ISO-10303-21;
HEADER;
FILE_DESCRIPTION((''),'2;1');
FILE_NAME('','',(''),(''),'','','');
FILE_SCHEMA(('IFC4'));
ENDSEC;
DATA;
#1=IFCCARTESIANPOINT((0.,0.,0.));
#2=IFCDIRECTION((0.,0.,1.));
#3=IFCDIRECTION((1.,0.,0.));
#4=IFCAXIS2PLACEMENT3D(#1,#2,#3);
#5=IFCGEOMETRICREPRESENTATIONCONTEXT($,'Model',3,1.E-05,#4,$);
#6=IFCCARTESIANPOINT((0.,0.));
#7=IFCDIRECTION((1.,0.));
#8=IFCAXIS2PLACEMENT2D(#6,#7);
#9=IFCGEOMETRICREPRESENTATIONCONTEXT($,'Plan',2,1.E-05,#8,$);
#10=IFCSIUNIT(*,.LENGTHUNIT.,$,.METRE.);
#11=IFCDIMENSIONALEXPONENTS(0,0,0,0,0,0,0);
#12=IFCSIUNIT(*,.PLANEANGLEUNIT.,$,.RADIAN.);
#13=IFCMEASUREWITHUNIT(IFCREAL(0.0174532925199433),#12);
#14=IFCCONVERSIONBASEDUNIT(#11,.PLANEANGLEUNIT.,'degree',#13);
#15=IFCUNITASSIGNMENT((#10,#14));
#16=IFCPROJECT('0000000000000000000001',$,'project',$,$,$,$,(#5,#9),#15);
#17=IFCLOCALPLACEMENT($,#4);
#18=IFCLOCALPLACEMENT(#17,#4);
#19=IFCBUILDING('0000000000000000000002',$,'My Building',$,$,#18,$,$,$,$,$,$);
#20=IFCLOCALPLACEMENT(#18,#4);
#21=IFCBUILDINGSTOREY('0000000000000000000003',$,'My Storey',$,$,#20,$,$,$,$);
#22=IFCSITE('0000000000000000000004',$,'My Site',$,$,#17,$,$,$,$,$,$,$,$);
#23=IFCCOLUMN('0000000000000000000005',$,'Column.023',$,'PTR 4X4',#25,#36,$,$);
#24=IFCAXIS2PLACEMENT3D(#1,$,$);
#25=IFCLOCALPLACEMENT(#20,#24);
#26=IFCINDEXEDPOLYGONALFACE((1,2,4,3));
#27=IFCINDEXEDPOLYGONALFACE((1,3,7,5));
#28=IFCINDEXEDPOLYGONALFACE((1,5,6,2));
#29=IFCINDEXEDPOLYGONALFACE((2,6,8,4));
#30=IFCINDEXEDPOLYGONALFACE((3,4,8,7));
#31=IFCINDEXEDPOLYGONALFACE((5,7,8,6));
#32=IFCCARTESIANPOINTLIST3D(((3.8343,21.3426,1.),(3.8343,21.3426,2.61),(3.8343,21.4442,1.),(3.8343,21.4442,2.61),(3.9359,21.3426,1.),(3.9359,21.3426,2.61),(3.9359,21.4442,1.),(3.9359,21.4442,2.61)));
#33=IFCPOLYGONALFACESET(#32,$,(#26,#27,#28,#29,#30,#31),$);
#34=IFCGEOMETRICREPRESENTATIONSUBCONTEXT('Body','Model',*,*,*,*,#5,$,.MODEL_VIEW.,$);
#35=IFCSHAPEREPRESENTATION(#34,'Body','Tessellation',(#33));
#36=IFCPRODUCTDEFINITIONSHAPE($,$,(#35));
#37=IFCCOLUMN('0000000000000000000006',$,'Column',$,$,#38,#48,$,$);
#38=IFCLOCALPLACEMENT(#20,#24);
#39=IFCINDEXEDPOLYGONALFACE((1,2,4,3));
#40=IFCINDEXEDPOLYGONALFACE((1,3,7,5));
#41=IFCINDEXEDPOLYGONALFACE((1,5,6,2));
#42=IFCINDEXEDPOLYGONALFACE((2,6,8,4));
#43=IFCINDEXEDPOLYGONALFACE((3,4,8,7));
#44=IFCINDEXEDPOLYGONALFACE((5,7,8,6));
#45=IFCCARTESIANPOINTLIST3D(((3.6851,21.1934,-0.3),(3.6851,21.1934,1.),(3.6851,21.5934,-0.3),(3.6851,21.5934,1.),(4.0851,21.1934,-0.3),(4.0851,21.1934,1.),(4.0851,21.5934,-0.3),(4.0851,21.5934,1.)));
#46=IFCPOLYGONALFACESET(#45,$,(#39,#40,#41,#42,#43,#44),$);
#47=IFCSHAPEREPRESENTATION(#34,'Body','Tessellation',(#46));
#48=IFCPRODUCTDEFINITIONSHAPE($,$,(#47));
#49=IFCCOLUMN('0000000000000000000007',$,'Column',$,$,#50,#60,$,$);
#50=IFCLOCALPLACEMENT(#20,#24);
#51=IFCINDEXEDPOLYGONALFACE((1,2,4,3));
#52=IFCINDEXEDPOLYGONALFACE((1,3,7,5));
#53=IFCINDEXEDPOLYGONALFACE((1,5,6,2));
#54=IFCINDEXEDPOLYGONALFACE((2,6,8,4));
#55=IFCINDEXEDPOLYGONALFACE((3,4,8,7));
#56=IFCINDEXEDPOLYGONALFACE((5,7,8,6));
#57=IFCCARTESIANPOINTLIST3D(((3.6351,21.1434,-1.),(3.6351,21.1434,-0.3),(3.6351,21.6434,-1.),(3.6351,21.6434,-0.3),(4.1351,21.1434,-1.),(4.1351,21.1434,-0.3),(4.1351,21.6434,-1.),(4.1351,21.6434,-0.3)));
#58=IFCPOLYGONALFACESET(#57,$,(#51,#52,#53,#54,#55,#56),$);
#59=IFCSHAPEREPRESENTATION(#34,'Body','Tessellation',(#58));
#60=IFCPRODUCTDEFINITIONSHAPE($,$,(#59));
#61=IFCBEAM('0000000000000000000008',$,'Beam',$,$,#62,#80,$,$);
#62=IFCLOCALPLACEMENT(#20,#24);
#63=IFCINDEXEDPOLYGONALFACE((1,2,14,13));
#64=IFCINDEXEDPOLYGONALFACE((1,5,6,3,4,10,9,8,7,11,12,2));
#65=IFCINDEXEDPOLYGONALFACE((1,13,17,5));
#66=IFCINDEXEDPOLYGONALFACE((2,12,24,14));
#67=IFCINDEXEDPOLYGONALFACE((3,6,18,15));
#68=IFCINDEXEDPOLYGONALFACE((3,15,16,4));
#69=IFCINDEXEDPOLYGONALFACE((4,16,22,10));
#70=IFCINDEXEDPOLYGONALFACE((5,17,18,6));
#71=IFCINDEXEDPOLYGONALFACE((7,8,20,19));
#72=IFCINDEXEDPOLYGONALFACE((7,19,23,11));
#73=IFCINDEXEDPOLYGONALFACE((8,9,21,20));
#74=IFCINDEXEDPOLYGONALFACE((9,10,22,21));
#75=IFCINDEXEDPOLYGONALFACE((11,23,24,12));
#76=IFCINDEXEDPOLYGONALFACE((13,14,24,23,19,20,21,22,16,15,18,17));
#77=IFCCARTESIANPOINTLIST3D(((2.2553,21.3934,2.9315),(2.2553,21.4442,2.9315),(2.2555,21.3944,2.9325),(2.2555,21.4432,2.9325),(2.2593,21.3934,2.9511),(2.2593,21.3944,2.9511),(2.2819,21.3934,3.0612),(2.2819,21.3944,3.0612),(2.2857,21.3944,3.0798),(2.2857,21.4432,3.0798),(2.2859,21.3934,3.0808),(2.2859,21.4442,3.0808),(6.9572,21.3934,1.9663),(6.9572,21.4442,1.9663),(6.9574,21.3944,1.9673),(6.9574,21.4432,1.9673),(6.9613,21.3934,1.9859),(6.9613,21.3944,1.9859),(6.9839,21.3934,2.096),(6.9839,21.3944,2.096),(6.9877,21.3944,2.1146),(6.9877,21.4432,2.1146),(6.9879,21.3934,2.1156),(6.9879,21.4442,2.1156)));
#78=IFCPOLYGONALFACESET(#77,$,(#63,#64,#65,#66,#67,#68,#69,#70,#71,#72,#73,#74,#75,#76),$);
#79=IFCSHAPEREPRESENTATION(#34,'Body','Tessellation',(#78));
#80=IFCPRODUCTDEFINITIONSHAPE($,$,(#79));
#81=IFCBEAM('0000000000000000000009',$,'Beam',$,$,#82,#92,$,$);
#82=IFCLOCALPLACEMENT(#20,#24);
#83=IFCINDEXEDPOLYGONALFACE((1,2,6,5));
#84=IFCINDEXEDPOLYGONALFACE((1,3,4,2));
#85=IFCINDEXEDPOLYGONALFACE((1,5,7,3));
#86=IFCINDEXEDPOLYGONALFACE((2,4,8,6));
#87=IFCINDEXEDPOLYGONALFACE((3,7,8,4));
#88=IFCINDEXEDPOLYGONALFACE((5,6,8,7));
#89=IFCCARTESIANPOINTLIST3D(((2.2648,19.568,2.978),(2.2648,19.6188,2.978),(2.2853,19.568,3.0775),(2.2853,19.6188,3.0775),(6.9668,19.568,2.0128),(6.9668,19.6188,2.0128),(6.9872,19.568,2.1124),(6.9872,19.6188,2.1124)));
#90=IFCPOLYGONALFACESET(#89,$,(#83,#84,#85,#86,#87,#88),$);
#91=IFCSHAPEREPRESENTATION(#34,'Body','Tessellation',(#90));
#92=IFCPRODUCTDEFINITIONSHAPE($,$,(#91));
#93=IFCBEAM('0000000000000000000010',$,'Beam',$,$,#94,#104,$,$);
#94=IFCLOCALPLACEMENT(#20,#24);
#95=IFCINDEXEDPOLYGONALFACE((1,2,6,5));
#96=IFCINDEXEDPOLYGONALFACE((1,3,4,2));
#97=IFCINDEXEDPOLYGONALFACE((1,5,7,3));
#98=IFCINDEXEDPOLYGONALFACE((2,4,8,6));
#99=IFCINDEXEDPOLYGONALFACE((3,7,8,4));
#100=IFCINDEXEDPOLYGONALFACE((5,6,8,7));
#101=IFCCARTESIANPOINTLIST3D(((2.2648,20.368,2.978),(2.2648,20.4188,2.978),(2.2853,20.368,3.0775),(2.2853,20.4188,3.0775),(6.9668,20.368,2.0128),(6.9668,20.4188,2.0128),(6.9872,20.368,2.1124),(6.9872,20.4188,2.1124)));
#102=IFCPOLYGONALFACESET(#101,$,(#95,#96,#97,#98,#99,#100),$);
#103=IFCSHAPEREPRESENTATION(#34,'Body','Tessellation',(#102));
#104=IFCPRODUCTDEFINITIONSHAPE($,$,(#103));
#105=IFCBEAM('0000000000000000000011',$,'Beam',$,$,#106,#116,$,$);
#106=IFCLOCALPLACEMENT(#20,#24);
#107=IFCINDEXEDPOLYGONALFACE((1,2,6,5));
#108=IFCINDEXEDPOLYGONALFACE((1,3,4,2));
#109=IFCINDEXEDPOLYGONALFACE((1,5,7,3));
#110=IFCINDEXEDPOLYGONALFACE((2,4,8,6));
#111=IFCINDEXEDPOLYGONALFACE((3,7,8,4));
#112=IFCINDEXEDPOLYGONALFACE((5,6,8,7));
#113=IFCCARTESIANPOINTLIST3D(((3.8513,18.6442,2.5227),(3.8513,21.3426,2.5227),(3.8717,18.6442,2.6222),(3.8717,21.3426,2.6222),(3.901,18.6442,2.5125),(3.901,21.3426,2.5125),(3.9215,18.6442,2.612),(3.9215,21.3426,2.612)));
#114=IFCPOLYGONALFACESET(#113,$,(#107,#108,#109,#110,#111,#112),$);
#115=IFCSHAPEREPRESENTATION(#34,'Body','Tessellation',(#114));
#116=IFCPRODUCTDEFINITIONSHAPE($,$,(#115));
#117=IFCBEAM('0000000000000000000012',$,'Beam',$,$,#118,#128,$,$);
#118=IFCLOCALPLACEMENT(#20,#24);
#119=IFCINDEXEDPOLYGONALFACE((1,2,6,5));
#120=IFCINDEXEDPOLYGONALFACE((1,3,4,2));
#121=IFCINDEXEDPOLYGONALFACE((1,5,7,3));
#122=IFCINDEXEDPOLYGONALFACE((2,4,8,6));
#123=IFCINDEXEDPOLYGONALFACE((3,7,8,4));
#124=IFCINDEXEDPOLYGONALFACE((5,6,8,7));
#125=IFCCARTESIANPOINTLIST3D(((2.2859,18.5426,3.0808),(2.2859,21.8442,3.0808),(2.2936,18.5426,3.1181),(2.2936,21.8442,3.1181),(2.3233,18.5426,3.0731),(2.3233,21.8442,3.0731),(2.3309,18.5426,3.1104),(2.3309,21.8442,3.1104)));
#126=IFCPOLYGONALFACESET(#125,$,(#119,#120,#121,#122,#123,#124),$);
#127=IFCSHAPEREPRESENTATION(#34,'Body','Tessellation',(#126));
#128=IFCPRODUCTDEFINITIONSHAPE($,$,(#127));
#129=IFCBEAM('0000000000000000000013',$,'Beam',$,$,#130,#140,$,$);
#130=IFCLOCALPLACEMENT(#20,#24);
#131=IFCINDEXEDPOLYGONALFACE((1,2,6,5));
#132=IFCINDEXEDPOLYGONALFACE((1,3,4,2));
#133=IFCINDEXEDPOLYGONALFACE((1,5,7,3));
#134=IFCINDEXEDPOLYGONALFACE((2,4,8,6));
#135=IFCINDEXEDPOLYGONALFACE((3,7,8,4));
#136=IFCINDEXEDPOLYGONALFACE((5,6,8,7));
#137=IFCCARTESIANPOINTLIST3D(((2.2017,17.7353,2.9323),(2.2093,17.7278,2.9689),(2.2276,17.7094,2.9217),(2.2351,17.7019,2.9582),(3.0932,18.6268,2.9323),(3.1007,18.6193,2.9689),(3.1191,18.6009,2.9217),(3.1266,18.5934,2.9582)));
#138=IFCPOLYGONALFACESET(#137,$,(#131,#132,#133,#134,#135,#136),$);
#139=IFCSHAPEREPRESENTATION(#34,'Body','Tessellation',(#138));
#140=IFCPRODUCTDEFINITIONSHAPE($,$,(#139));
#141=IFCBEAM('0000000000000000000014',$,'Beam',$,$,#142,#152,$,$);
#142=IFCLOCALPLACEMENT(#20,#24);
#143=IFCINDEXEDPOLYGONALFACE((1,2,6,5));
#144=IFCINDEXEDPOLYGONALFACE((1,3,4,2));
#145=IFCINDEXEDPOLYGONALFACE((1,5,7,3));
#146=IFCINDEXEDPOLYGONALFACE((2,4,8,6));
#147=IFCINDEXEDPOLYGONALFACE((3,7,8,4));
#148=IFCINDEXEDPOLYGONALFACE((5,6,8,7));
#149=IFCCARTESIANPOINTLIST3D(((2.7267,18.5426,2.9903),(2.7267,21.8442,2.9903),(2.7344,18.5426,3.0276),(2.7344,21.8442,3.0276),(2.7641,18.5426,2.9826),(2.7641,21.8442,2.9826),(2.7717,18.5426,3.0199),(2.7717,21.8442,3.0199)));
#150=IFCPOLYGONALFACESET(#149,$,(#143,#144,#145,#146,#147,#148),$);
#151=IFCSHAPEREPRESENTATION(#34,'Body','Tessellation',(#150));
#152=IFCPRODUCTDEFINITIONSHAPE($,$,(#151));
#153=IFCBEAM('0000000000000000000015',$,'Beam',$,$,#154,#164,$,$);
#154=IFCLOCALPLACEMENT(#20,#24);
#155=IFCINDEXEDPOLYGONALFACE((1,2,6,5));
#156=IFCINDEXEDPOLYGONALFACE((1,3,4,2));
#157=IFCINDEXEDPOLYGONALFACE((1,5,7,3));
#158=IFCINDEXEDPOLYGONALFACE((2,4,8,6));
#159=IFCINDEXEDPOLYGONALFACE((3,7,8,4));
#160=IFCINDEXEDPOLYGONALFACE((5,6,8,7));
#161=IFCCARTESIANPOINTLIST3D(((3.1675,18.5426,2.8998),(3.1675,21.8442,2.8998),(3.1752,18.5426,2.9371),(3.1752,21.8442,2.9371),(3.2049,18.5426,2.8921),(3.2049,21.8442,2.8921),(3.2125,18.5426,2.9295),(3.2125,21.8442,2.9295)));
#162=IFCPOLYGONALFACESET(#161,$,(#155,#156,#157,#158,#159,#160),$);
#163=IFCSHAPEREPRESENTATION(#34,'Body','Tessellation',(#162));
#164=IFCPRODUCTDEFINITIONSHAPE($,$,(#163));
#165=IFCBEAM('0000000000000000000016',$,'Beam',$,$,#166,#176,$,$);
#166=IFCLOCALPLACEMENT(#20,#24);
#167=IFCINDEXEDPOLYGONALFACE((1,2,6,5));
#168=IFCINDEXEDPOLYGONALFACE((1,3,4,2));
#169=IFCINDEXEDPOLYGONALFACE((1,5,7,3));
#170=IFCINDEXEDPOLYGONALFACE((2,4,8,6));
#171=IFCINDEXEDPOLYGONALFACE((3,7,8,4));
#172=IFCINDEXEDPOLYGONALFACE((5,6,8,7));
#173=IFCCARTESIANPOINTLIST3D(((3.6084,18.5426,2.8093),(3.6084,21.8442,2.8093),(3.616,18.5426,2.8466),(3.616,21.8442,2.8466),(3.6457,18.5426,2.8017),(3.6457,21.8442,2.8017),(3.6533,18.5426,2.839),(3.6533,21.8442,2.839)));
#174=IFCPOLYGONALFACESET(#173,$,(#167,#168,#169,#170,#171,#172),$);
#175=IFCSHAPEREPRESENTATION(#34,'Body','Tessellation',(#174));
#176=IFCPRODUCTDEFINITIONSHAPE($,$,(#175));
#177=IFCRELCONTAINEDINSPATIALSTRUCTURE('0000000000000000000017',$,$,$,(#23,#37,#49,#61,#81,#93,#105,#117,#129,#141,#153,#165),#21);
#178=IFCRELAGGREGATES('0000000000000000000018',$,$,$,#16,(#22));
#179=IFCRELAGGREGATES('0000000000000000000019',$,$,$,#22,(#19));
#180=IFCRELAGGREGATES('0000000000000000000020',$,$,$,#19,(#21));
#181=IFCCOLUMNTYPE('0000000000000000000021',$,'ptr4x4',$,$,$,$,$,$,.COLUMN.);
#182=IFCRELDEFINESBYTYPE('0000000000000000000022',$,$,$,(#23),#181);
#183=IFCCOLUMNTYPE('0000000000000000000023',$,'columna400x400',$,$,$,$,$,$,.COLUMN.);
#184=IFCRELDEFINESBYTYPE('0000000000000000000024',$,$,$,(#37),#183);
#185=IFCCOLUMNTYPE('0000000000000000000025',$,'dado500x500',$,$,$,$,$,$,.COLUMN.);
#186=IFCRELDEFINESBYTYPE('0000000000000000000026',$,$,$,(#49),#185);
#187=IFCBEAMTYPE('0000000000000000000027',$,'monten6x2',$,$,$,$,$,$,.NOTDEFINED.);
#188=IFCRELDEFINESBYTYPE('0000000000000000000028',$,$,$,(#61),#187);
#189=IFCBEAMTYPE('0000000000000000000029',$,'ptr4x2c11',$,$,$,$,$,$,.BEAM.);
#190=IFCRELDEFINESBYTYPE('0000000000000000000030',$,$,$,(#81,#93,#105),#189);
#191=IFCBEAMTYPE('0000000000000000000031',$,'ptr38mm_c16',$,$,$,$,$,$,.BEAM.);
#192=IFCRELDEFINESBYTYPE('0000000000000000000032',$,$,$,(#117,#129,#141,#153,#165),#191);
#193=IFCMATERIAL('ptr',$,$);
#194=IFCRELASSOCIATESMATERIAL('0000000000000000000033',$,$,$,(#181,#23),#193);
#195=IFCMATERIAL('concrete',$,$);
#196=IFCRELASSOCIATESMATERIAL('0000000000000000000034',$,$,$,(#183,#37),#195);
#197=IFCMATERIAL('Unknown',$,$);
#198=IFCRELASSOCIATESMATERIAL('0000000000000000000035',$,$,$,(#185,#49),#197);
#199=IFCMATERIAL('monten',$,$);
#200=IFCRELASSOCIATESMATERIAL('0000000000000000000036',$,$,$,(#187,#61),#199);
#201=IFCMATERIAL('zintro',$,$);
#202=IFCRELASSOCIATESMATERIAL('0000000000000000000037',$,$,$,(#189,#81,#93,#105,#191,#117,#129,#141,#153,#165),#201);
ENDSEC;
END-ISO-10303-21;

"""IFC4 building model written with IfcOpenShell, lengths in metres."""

from ifc_helpers import new_model, entity, si_unit, converted_unit, frame, origin_with_axes, origin_2d_with_axis, place, context, subcontext, project, spatial, rectangle, c_section, extrude, material, material_profile, profile_set, profile_usage, type_object, element, save


model = new_model("IFC4")

# Units and contexts
model_context = context("Model", 3, precision=1e-05, world=origin_with_axes())
plan_context = context("Plan", 2, precision=1e-05, world=origin_2d_with_axis())
body_context = subcontext(model_context, "Body", "Model", "MODEL_VIEW")
ifc_project = project(units=[si_unit("LENGTHUNIT", "METRE"), converted_unit("PLANEANGLEUNIT", "degree", entity("IfcReal", 0.0174532925199433), si_unit("PLANEANGLEUNIT", "RADIAN"), dimensions=[0, 0, 0, 0, 0, 0, 0])], contexts=[model_context, plan_context])

# Site, building, storey
site_placement = place(None, origin_with_axes())
site = spatial("IfcSite", under=ifc_project, at=site_placement, Name="My Site")
building_placement = place(site_placement, origin_with_axes())
building = spatial("IfcBuilding", under=site, at=building_placement, Name="My Building")
storey_placement = place(building_placement, origin_with_axes())
storey = spatial("IfcBuildingStorey", under=building, at=storey_placement, Name="My Storey")

# Columns
ifc_material_1 = material(Name="ptr")
ifc_material_profile_1 = material_profile(ifc_material_1, rectangle(XDim=0.1016, YDim=0.1016))
ifc_profile_set_1 = profile_set([ifc_material_profile_1])
ifc_profile_usage_1 = profile_usage(ifc_profile_set_1, cardinal=5)
column_type_1 = type_object("IfcColumnType", Name="ptr4x4", PredefinedType="COLUMN", material=ifc_profile_set_1)
column_1_placement = place(storey_placement, frame((3.8851, 21.3934, 1.0), z_axis=(0.0, 0.0, 1.0), x_axis=(0.0, 1.0, 0.0)))
element("IfcColumn", 1, at=column_1_placement, inside=storey, type_object=column_type_1, material=ifc_profile_usage_1, Name="Column.023", ObjectType="PTR 4X4", context=body_context, shape_type="SweptSolid", body=[
    extrude(rectangle(XDim=0.1016, YDim=0.1016), origin_with_axes(), (0.0, 0.0, 1.0), 1.61),
])
ifc_material_2 = material(Name="concrete")
ifc_material_profile_2 = material_profile(ifc_material_2, rectangle(XDim=0.4, YDim=0.4))
ifc_profile_set_2 = profile_set([ifc_material_profile_2], Name="concrete")
ifc_profile_usage_2 = profile_usage(ifc_profile_set_2)
column_type_2 = type_object("IfcColumnType", Name="columna400x400", PredefinedType="COLUMN", material=ifc_profile_set_2)
column_2_placement = place(storey_placement, frame((3.8851, 21.3934, -0.3), z_axis=(0.0, 0.0, 1.0), x_axis=(1.0, 0.0, 0.0)))
element("IfcColumn", 2, at=column_2_placement, inside=storey, type_object=column_type_2, material=ifc_profile_usage_2, Name="Column", context=body_context, shape_type="SweptSolid", body=[
    extrude(rectangle(XDim=0.4, YDim=0.4), origin_with_axes(), (0.0, 0.0, 1.0), 1.3),
])
ifc_material_3 = material(Name="Unknown")
ifc_material_profile_3 = material_profile(ifc_material_3, rectangle(XDim=0.5, YDim=0.5))
ifc_profile_set_3 = profile_set([ifc_material_profile_3], Name="concrete")
ifc_profile_usage_3 = profile_usage(ifc_profile_set_3)
column_type_3 = type_object("IfcColumnType", Name="dado500x500", PredefinedType="COLUMN", material=ifc_profile_set_3)
column_3_placement = place(storey_placement, frame((3.8851, 21.3934, -1.0), z_axis=(0.0, 0.0, 1.0), x_axis=(1.0, 0.0, 0.0)))
element("IfcColumn", 3, at=column_3_placement, inside=storey, type_object=column_type_3, material=ifc_profile_usage_3, Name="Column", context=body_context, shape_type="SweptSolid", body=[
    extrude(rectangle(XDim=0.5, YDim=0.5), origin_with_axes(), (0.0, 0.0, 1.0), 0.7),
])

# Beams
ifc_material_4 = material(Name="monten")
ifc_material_profile_4 = material_profile(ifc_material_4, c_section(Depth=0.1524, Width=0.0508, WallThickness=0.001, Girth=0.02))
ifc_profile_set_4 = profile_set([ifc_material_profile_4])
ifc_profile_usage_4 = profile_usage(ifc_profile_set_4, cardinal=5)
beam_type_1 = type_object("IfcBeamType", Name="monten6x2", PredefinedType="NOTDEFINED", material=ifc_profile_set_4)
beam_1_placement = place(storey_placement, frame((2.2706, 21.4188, 3.0061), z_axis=(0.979575, 0.0, -0.201078), x_axis=(0.0, -1.0, 0.000001)))
element("IfcBeam", 4, at=beam_1_placement, inside=storey, type_object=beam_type_1, material=ifc_profile_usage_4, Name="Beam", context=body_context, shape_type="SweptSolid", body=[
    extrude(c_section(Depth=0.1524, Width=0.0508, WallThickness=0.001, Girth=0.02), origin_with_axes(), (0.0, 0.0, 1.0), 4.8),
])
ifc_material_5 = material(Name="zintro")
ifc_material_profile_5 = material_profile(ifc_material_5, rectangle(XDim=0.0508, YDim=0.1016))
ifc_profile_set_5 = profile_set([ifc_material_profile_5])
ifc_profile_usage_5 = profile_usage(ifc_profile_set_5)
beam_type_2 = type_object("IfcBeamType", Name="ptr4x2c11", PredefinedType="BEAM", material=ifc_profile_set_5)
beam_2_placement = place(storey_placement, frame((2.275, 19.5934, 3.0278), z_axis=(0.979575, 0.0, -0.201078), x_axis=(0.0, 1.0, 0.0)))
element("IfcBeam", 5, at=beam_2_placement, inside=storey, type_object=beam_type_2, material=ifc_profile_usage_5, Name="Beam", context=body_context, shape_type="SweptSolid", body=[
    extrude(rectangle(XDim=0.0508, YDim=0.1016), origin_with_axes(), (0.0, 0.0, 1.0), 4.8),
])
ifc_profile_usage_6 = profile_usage(ifc_profile_set_5)
beam_3_placement = place(storey_placement, frame((2.275, 20.3934, 3.0278), z_axis=(0.979575, 0.0, -0.201078), x_axis=(0.0, 1.0, 0.0)))
element("IfcBeam", 6, at=beam_3_placement, inside=storey, type_object=beam_type_2, material=ifc_profile_usage_6, Name="Beam", context=body_context, shape_type="SweptSolid", body=[
    extrude(rectangle(XDim=0.0508, YDim=0.1016), origin_with_axes(), (0.0, 0.0, 1.0), 4.8),
])
ifc_profile_usage_7 = profile_usage(ifc_profile_set_5)
beam_4_placement = place(storey_placement, frame((3.8864, 18.6442, 2.5674), z_axis=(0.0, 1.0, 0.0), x_axis=(-0.979575, 0.0, 0.201078)))
element("IfcBeam", 7, at=beam_4_placement, inside=storey, type_object=beam_type_2, material=ifc_profile_usage_7, Name="Beam", context=body_context, shape_type="SweptSolid", body=[
    extrude(rectangle(XDim=0.0508, YDim=0.1016), origin_with_axes(), (0.0, 0.0, 1.0), 2.6984),
])
ifc_material_profile_6 = material_profile(ifc_material_5, rectangle(XDim=0.0381, YDim=0.0381))
ifc_profile_set_6 = profile_set([ifc_material_profile_6])
ifc_profile_usage_8 = profile_usage(ifc_profile_set_6)
beam_type_3 = type_object("IfcBeamType", Name="ptr38mm_c16", PredefinedType="BEAM", material=ifc_profile_set_6)
beam_5_placement = place(storey_placement, frame((2.3084, 21.8442, 3.0956), z_axis=(0.0, -1.0, 0.0), x_axis=(0.979575, 0.0, -0.201078)))
element("IfcBeam", 8, at=beam_5_placement, inside=storey, type_object=beam_type_3, material=ifc_profile_usage_8, Name="Beam", context=body_context, shape_type="SweptSolid", body=[
    extrude(rectangle(XDim=0.0381, YDim=0.0381), origin_with_axes(), (0.0, 0.0, 1.0), 3.3016),
])
ifc_profile_usage_9 = profile_usage(ifc_profile_set_6)
beam_6_placement = place(storey_placement, frame((3.1099, 18.6101, 2.9453), z_axis=(-0.707107, -0.707107, 0.0), x_axis=(0.67903, -0.67903, -0.278991)))
element("IfcBeam", 9, at=beam_6_placement, inside=storey, type_object=beam_type_3, material=ifc_profile_usage_9, Name="Beam", context=body_context, shape_type="SweptSolid", body=[
    extrude(rectangle(XDim=0.0381, YDim=0.0381), origin_with_axes(), (0.0, 0.0, 1.0), 1.2607),
])
ifc_profile_usage_10 = profile_usage(ifc_profile_set_6)
beam_7_placement = place(storey_placement, frame((2.7492, 21.8442, 3.0051), z_axis=(0.0, -1.0, 0.0), x_axis=(0.979575, 0.0, -0.201078)))
element("IfcBeam", 10, at=beam_7_placement, inside=storey, type_object=beam_type_3, material=ifc_profile_usage_10, Name="Beam", context=body_context, shape_type="SweptSolid", body=[
    extrude(rectangle(XDim=0.0381, YDim=0.0381), origin_with_axes(), (0.0, 0.0, 1.0), 3.3016),
])
ifc_profile_usage_11 = profile_usage(ifc_profile_set_6)
beam_8_placement = place(storey_placement, frame((3.19, 21.8442, 2.9146), z_axis=(0.0, -1.0, 0.0), x_axis=(0.979575, 0.0, -0.201078)))
element("IfcBeam", 11, at=beam_8_placement, inside=storey, type_object=beam_type_3, material=ifc_profile_usage_11, Name="Beam", context=body_context, shape_type="SweptSolid", body=[
    extrude(rectangle(XDim=0.0381, YDim=0.0381), origin_with_axes(), (0.0, 0.0, 1.0), 3.3016),
])
ifc_profile_usage_12 = profile_usage(ifc_profile_set_6)
beam_9_placement = place(storey_placement, frame((3.6308, 21.8442, 2.8241), z_axis=(0.0, -1.0, 0.0), x_axis=(0.979575, 0.0, -0.201078)))
element("IfcBeam", 12, at=beam_9_placement, inside=storey, type_object=beam_type_3, material=ifc_profile_usage_12, Name="Beam", context=body_context, shape_type="SweptSolid", body=[
    extrude(rectangle(XDim=0.0381, YDim=0.0381), origin_with_axes(), (0.0, 0.0, 1.0), 3.3016),
])

save(model, "model.ifc")
